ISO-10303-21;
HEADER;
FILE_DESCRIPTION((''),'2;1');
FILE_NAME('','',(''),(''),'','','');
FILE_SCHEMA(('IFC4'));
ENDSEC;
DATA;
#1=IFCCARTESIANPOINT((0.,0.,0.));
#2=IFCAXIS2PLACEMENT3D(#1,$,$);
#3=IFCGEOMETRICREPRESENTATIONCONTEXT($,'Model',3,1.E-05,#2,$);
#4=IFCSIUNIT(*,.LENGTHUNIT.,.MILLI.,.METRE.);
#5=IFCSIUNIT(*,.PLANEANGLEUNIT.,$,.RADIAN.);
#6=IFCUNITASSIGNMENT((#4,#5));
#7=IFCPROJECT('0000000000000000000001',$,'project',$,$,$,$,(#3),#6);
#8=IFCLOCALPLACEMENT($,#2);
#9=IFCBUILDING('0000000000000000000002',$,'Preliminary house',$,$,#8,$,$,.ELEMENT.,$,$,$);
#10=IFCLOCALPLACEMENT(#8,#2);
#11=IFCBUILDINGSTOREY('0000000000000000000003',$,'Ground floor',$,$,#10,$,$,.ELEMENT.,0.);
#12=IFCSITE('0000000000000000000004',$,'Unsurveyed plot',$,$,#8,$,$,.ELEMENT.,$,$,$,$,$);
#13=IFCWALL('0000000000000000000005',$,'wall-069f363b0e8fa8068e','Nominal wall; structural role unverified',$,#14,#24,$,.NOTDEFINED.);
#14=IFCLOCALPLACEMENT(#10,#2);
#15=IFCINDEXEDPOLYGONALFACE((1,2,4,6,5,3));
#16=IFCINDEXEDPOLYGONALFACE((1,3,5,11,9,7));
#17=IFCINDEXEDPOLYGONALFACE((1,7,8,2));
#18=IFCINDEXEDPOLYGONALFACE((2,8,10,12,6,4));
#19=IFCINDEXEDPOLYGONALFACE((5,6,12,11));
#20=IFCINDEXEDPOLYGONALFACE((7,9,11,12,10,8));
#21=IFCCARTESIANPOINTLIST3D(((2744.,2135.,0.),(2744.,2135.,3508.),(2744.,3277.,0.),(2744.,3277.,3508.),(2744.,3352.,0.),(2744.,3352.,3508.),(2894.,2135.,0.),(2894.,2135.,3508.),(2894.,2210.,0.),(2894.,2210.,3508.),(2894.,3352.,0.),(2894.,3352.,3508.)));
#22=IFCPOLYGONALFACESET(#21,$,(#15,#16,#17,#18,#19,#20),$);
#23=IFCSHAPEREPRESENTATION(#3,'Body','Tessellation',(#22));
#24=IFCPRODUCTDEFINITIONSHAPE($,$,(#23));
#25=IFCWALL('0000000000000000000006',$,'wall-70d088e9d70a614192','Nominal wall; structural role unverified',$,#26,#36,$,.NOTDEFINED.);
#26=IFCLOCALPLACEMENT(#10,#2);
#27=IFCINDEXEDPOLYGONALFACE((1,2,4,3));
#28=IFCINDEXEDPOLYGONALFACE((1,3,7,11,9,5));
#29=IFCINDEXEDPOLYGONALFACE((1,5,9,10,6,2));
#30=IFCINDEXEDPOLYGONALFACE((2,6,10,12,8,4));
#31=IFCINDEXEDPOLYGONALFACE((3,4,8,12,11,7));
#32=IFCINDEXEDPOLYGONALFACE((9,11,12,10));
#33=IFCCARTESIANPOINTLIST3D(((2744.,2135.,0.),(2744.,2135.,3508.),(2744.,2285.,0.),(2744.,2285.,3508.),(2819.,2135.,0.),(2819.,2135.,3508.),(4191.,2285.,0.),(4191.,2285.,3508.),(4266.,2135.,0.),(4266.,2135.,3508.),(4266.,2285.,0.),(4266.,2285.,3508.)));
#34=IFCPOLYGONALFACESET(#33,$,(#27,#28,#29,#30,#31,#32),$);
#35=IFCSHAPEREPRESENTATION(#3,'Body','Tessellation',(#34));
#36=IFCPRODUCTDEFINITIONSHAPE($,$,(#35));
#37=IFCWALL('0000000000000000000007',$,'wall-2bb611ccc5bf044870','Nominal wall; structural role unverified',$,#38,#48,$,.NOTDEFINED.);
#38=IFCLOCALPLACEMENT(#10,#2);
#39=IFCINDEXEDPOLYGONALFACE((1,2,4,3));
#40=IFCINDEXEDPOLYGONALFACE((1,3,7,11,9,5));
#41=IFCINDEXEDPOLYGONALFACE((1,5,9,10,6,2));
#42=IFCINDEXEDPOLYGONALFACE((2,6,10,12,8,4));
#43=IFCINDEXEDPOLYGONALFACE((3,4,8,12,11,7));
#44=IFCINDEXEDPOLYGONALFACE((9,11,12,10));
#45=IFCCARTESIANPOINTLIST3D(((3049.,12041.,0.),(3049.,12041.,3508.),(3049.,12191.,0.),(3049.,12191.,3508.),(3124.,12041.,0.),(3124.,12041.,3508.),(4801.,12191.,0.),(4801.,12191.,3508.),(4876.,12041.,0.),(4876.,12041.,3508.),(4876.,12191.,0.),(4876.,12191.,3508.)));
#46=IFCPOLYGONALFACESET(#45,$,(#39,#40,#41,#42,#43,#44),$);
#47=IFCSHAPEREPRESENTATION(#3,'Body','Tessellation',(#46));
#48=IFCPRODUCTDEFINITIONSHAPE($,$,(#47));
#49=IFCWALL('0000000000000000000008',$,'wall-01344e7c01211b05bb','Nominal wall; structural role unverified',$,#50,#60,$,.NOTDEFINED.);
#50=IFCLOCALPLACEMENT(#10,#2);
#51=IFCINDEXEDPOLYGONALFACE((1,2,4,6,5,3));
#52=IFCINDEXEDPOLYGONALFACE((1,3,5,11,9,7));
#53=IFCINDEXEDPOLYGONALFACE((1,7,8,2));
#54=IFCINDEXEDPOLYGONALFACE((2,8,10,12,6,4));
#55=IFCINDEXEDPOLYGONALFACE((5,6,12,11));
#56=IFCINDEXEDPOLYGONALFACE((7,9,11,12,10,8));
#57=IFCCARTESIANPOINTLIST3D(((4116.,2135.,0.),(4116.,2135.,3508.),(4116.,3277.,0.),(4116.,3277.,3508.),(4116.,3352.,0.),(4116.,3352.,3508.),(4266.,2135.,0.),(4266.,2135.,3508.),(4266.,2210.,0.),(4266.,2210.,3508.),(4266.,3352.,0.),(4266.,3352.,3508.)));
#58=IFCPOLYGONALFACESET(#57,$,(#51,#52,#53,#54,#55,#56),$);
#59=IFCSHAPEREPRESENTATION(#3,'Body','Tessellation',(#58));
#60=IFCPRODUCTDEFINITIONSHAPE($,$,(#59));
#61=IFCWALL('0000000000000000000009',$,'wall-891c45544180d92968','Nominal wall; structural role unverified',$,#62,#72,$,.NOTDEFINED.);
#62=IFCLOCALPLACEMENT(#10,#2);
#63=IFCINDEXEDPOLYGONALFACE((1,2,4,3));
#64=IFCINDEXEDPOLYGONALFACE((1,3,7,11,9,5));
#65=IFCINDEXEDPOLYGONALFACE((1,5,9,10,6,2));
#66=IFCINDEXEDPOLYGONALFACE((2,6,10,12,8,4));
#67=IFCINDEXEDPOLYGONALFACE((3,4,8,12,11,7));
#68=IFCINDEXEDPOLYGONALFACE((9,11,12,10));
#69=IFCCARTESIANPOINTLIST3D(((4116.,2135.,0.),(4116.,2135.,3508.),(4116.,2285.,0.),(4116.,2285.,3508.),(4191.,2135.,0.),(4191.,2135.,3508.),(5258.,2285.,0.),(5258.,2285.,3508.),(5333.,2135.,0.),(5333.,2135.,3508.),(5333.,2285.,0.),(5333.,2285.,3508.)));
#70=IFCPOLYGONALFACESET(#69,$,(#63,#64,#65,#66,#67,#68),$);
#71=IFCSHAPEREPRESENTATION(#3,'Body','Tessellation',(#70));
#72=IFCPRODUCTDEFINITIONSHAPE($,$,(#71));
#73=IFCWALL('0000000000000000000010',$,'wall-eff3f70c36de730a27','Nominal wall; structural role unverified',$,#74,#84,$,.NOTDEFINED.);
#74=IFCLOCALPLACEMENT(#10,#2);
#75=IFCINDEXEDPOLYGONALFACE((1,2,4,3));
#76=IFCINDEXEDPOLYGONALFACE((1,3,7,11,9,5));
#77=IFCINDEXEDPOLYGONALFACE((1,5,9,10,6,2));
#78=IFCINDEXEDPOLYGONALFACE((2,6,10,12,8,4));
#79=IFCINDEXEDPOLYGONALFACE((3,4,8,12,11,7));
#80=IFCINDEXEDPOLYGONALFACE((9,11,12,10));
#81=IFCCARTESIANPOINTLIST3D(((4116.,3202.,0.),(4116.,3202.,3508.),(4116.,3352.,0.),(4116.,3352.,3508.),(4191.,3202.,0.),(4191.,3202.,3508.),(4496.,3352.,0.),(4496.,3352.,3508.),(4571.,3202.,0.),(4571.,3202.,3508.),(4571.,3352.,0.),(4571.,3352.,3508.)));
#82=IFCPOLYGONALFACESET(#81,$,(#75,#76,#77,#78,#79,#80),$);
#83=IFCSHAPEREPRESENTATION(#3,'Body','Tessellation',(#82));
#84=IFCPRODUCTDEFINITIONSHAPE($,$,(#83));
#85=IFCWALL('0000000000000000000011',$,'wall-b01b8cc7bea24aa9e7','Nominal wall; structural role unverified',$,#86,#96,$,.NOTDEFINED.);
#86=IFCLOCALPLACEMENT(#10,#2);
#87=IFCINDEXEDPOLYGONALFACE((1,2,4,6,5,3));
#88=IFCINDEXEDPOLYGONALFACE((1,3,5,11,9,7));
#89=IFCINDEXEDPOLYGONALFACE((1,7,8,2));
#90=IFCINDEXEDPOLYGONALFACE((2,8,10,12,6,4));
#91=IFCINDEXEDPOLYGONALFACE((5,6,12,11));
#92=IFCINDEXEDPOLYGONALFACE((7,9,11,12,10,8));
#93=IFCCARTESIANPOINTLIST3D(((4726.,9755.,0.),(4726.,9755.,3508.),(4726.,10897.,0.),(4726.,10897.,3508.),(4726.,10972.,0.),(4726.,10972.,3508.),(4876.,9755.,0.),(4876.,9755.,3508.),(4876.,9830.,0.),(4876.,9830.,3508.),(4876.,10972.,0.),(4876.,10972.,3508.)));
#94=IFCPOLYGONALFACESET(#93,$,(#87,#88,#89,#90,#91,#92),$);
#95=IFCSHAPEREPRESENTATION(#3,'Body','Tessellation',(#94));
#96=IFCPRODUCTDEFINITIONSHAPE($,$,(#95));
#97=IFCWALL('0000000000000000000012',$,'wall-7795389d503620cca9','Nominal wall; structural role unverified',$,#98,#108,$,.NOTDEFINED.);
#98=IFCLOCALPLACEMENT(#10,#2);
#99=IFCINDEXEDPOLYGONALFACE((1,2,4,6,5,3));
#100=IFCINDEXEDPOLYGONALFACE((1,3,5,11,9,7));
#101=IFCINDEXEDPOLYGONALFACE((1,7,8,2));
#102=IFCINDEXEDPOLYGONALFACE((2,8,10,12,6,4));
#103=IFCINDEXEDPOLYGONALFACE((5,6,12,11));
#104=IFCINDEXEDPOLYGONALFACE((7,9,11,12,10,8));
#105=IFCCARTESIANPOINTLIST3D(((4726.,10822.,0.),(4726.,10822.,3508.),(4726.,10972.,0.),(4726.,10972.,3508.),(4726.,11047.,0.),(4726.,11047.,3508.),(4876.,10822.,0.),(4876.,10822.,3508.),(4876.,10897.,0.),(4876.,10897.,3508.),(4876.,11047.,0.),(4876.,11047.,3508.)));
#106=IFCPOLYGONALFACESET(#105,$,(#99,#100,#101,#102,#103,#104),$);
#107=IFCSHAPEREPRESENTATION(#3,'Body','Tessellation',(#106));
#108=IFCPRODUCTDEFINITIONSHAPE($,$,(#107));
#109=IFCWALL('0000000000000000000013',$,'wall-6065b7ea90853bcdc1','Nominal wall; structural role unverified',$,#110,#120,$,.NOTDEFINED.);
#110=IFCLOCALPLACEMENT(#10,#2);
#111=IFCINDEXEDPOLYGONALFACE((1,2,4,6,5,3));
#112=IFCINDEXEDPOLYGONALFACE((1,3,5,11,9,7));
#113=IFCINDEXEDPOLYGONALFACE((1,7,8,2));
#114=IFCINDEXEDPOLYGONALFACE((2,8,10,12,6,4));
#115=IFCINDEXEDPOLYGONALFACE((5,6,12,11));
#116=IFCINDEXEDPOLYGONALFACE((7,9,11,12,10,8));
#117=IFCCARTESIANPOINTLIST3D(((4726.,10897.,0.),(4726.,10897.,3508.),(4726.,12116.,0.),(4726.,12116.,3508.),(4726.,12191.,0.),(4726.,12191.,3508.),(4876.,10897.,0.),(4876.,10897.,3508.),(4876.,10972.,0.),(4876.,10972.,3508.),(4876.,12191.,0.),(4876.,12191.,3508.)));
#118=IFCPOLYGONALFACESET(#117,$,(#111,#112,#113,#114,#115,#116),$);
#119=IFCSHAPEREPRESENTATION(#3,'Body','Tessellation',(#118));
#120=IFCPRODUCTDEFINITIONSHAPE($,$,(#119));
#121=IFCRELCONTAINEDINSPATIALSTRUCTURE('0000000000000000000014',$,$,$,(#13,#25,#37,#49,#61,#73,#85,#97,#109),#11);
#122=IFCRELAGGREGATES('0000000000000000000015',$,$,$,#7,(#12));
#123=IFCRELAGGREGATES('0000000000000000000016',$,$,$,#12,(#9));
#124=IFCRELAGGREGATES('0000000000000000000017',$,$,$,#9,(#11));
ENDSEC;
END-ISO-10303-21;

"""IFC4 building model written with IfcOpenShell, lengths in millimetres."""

from ifc_helpers import new_model, si_unit, origin, place, context, project, spatial, polyline, outline, extrude, element, save


model = new_model("IFC4")

# Units and contexts
model_context = context("Model", 3, precision=1e-05, world=origin())
ifc_project = project(units=[si_unit("LENGTHUNIT", "METRE", prefix="MILLI"), si_unit("PLANEANGLEUNIT", "RADIAN")], contexts=[model_context])

# Site, building, storey
placement_1 = place(None, origin())
site = spatial("IfcSite", under=ifc_project, at=placement_1, Name="Unsurveyed plot", CompositionType="ELEMENT")
building = spatial("IfcBuilding", under=site, at=placement_1, Name="Preliminary house", CompositionType="ELEMENT")
placement_2 = place(placement_1, origin())
storey = spatial("IfcBuildingStorey", under=building, at=placement_2, Name="Ground floor", CompositionType="ELEMENT", Elevation=0.0)

# Walls
element("IfcWall", 1, at=placement_2, inside=storey, Name="wall-069f363b0e8fa8068e", Description="Nominal wall; structural role unverified", PredefinedType="NOTDEFINED", context=model_context, shape_type="SweptSolid", body=[
    extrude(outline(polyline([(2744.0, 3277.0), (2744.0, 3352.0), (2894.0, 3352.0), (2894.0, 2210.0), (2894.0, 2135.0), (2744.0, 2135.0), (2744.0, 3277.0)])), origin(), (0.0, 0.0, 1.0), 3508.0),
])
element("IfcWall", 2, at=placement_2, inside=storey, Name="wall-70d088e9d70a614192", Description="Nominal wall; structural role unverified", PredefinedType="NOTDEFINED", context=model_context, shape_type="SweptSolid", body=[
    extrude(outline(polyline([(4191.0, 2285.0), (4266.0, 2285.0), (4266.0, 2135.0), (2819.0, 2135.0), (2744.0, 2135.0), (2744.0, 2285.0), (4191.0, 2285.0)])), origin(), (0.0, 0.0, 1.0), 3508.0),
])

# Wall
element("IfcWall", 3, at=placement_2, inside=storey, Name="wall-2bb611ccc5bf044870", Description="Nominal wall; structural role unverified", PredefinedType="NOTDEFINED", context=model_context, shape_type="SweptSolid", body=[
    extrude(outline(polyline([(4801.0, 12191.0), (4876.0, 12191.0), (4876.0, 12041.0), (3124.0, 12041.0), (3049.0, 12041.0), (3049.0, 12191.0), (4801.0, 12191.0)])), origin(), (0.0, 0.0, 1.0), 3508.0),
])

# Walls
element("IfcWall", 4, at=placement_2, inside=storey, Name="wall-01344e7c01211b05bb", Description="Nominal wall; structural role unverified", PredefinedType="NOTDEFINED", context=model_context, shape_type="SweptSolid", body=[
    extrude(outline(polyline([(4116.0, 3277.0), (4116.0, 3352.0), (4266.0, 3352.0), (4266.0, 2210.0), (4266.0, 2135.0), (4116.0, 2135.0), (4116.0, 3277.0)])), origin(), (0.0, 0.0, 1.0), 3508.0),
])
element("IfcWall", 5, at=placement_2, inside=storey, Name="wall-891c45544180d92968", Description="Nominal wall; structural role unverified", PredefinedType="NOTDEFINED", context=model_context, shape_type="SweptSolid", body=[
    extrude(outline(polyline([(5258.0, 2285.0), (5333.0, 2285.0), (5333.0, 2135.0), (4191.0, 2135.0), (4116.0, 2135.0), (4116.0, 2285.0), (5258.0, 2285.0)])), origin(), (0.0, 0.0, 1.0), 3508.0),
])
element("IfcWall", 6, at=placement_2, inside=storey, Name="wall-eff3f70c36de730a27", Description="Nominal wall; structural role unverified", PredefinedType="NOTDEFINED", context=model_context, shape_type="SweptSolid", body=[
    extrude(outline(polyline([(4496.0, 3352.0), (4571.0, 3352.0), (4571.0, 3202.0), (4191.0, 3202.0), (4116.0, 3202.0), (4116.0, 3352.0), (4496.0, 3352.0)])), origin(), (0.0, 0.0, 1.0), 3508.0),
])

# Wall
element("IfcWall", 7, at=placement_2, inside=storey, Name="wall-b01b8cc7bea24aa9e7", Description="Nominal wall; structural role unverified", PredefinedType="NOTDEFINED", context=model_context, shape_type="SweptSolid", body=[
    extrude(outline(polyline([(4726.0, 10897.0), (4726.0, 10972.0), (4876.0, 10972.0), (4876.0, 9830.0), (4876.0, 9755.0), (4726.0, 9755.0), (4726.0, 10897.0)])), origin(), (0.0, 0.0, 1.0), 3508.0),
])

# Walls
element("IfcWall", 8, at=placement_2, inside=storey, Name="wall-7795389d503620cca9", Description="Nominal wall; structural role unverified", PredefinedType="NOTDEFINED", context=model_context, shape_type="SweptSolid", body=[
    extrude(outline(polyline([(4726.0, 10972.0), (4726.0, 11047.0), (4876.0, 11047.0), (4876.0, 10897.0), (4876.0, 10822.0), (4726.0, 10822.0), (4726.0, 10972.0)])), origin(), (0.0, 0.0, 1.0), 3508.0),
])
element("IfcWall", 9, at=placement_2, inside=storey, Name="wall-6065b7ea90853bcdc1", Description="Nominal wall; structural role unverified", PredefinedType="NOTDEFINED", context=model_context, shape_type="SweptSolid", body=[
    extrude(outline(polyline([(4726.0, 12116.0), (4726.0, 12191.0), (4876.0, 12191.0), (4876.0, 10972.0), (4876.0, 10897.0), (4726.0, 10897.0), (4726.0, 12116.0)])), origin(), (0.0, 0.0, 1.0), 3508.0),
])

save(model, "model.ifc")
